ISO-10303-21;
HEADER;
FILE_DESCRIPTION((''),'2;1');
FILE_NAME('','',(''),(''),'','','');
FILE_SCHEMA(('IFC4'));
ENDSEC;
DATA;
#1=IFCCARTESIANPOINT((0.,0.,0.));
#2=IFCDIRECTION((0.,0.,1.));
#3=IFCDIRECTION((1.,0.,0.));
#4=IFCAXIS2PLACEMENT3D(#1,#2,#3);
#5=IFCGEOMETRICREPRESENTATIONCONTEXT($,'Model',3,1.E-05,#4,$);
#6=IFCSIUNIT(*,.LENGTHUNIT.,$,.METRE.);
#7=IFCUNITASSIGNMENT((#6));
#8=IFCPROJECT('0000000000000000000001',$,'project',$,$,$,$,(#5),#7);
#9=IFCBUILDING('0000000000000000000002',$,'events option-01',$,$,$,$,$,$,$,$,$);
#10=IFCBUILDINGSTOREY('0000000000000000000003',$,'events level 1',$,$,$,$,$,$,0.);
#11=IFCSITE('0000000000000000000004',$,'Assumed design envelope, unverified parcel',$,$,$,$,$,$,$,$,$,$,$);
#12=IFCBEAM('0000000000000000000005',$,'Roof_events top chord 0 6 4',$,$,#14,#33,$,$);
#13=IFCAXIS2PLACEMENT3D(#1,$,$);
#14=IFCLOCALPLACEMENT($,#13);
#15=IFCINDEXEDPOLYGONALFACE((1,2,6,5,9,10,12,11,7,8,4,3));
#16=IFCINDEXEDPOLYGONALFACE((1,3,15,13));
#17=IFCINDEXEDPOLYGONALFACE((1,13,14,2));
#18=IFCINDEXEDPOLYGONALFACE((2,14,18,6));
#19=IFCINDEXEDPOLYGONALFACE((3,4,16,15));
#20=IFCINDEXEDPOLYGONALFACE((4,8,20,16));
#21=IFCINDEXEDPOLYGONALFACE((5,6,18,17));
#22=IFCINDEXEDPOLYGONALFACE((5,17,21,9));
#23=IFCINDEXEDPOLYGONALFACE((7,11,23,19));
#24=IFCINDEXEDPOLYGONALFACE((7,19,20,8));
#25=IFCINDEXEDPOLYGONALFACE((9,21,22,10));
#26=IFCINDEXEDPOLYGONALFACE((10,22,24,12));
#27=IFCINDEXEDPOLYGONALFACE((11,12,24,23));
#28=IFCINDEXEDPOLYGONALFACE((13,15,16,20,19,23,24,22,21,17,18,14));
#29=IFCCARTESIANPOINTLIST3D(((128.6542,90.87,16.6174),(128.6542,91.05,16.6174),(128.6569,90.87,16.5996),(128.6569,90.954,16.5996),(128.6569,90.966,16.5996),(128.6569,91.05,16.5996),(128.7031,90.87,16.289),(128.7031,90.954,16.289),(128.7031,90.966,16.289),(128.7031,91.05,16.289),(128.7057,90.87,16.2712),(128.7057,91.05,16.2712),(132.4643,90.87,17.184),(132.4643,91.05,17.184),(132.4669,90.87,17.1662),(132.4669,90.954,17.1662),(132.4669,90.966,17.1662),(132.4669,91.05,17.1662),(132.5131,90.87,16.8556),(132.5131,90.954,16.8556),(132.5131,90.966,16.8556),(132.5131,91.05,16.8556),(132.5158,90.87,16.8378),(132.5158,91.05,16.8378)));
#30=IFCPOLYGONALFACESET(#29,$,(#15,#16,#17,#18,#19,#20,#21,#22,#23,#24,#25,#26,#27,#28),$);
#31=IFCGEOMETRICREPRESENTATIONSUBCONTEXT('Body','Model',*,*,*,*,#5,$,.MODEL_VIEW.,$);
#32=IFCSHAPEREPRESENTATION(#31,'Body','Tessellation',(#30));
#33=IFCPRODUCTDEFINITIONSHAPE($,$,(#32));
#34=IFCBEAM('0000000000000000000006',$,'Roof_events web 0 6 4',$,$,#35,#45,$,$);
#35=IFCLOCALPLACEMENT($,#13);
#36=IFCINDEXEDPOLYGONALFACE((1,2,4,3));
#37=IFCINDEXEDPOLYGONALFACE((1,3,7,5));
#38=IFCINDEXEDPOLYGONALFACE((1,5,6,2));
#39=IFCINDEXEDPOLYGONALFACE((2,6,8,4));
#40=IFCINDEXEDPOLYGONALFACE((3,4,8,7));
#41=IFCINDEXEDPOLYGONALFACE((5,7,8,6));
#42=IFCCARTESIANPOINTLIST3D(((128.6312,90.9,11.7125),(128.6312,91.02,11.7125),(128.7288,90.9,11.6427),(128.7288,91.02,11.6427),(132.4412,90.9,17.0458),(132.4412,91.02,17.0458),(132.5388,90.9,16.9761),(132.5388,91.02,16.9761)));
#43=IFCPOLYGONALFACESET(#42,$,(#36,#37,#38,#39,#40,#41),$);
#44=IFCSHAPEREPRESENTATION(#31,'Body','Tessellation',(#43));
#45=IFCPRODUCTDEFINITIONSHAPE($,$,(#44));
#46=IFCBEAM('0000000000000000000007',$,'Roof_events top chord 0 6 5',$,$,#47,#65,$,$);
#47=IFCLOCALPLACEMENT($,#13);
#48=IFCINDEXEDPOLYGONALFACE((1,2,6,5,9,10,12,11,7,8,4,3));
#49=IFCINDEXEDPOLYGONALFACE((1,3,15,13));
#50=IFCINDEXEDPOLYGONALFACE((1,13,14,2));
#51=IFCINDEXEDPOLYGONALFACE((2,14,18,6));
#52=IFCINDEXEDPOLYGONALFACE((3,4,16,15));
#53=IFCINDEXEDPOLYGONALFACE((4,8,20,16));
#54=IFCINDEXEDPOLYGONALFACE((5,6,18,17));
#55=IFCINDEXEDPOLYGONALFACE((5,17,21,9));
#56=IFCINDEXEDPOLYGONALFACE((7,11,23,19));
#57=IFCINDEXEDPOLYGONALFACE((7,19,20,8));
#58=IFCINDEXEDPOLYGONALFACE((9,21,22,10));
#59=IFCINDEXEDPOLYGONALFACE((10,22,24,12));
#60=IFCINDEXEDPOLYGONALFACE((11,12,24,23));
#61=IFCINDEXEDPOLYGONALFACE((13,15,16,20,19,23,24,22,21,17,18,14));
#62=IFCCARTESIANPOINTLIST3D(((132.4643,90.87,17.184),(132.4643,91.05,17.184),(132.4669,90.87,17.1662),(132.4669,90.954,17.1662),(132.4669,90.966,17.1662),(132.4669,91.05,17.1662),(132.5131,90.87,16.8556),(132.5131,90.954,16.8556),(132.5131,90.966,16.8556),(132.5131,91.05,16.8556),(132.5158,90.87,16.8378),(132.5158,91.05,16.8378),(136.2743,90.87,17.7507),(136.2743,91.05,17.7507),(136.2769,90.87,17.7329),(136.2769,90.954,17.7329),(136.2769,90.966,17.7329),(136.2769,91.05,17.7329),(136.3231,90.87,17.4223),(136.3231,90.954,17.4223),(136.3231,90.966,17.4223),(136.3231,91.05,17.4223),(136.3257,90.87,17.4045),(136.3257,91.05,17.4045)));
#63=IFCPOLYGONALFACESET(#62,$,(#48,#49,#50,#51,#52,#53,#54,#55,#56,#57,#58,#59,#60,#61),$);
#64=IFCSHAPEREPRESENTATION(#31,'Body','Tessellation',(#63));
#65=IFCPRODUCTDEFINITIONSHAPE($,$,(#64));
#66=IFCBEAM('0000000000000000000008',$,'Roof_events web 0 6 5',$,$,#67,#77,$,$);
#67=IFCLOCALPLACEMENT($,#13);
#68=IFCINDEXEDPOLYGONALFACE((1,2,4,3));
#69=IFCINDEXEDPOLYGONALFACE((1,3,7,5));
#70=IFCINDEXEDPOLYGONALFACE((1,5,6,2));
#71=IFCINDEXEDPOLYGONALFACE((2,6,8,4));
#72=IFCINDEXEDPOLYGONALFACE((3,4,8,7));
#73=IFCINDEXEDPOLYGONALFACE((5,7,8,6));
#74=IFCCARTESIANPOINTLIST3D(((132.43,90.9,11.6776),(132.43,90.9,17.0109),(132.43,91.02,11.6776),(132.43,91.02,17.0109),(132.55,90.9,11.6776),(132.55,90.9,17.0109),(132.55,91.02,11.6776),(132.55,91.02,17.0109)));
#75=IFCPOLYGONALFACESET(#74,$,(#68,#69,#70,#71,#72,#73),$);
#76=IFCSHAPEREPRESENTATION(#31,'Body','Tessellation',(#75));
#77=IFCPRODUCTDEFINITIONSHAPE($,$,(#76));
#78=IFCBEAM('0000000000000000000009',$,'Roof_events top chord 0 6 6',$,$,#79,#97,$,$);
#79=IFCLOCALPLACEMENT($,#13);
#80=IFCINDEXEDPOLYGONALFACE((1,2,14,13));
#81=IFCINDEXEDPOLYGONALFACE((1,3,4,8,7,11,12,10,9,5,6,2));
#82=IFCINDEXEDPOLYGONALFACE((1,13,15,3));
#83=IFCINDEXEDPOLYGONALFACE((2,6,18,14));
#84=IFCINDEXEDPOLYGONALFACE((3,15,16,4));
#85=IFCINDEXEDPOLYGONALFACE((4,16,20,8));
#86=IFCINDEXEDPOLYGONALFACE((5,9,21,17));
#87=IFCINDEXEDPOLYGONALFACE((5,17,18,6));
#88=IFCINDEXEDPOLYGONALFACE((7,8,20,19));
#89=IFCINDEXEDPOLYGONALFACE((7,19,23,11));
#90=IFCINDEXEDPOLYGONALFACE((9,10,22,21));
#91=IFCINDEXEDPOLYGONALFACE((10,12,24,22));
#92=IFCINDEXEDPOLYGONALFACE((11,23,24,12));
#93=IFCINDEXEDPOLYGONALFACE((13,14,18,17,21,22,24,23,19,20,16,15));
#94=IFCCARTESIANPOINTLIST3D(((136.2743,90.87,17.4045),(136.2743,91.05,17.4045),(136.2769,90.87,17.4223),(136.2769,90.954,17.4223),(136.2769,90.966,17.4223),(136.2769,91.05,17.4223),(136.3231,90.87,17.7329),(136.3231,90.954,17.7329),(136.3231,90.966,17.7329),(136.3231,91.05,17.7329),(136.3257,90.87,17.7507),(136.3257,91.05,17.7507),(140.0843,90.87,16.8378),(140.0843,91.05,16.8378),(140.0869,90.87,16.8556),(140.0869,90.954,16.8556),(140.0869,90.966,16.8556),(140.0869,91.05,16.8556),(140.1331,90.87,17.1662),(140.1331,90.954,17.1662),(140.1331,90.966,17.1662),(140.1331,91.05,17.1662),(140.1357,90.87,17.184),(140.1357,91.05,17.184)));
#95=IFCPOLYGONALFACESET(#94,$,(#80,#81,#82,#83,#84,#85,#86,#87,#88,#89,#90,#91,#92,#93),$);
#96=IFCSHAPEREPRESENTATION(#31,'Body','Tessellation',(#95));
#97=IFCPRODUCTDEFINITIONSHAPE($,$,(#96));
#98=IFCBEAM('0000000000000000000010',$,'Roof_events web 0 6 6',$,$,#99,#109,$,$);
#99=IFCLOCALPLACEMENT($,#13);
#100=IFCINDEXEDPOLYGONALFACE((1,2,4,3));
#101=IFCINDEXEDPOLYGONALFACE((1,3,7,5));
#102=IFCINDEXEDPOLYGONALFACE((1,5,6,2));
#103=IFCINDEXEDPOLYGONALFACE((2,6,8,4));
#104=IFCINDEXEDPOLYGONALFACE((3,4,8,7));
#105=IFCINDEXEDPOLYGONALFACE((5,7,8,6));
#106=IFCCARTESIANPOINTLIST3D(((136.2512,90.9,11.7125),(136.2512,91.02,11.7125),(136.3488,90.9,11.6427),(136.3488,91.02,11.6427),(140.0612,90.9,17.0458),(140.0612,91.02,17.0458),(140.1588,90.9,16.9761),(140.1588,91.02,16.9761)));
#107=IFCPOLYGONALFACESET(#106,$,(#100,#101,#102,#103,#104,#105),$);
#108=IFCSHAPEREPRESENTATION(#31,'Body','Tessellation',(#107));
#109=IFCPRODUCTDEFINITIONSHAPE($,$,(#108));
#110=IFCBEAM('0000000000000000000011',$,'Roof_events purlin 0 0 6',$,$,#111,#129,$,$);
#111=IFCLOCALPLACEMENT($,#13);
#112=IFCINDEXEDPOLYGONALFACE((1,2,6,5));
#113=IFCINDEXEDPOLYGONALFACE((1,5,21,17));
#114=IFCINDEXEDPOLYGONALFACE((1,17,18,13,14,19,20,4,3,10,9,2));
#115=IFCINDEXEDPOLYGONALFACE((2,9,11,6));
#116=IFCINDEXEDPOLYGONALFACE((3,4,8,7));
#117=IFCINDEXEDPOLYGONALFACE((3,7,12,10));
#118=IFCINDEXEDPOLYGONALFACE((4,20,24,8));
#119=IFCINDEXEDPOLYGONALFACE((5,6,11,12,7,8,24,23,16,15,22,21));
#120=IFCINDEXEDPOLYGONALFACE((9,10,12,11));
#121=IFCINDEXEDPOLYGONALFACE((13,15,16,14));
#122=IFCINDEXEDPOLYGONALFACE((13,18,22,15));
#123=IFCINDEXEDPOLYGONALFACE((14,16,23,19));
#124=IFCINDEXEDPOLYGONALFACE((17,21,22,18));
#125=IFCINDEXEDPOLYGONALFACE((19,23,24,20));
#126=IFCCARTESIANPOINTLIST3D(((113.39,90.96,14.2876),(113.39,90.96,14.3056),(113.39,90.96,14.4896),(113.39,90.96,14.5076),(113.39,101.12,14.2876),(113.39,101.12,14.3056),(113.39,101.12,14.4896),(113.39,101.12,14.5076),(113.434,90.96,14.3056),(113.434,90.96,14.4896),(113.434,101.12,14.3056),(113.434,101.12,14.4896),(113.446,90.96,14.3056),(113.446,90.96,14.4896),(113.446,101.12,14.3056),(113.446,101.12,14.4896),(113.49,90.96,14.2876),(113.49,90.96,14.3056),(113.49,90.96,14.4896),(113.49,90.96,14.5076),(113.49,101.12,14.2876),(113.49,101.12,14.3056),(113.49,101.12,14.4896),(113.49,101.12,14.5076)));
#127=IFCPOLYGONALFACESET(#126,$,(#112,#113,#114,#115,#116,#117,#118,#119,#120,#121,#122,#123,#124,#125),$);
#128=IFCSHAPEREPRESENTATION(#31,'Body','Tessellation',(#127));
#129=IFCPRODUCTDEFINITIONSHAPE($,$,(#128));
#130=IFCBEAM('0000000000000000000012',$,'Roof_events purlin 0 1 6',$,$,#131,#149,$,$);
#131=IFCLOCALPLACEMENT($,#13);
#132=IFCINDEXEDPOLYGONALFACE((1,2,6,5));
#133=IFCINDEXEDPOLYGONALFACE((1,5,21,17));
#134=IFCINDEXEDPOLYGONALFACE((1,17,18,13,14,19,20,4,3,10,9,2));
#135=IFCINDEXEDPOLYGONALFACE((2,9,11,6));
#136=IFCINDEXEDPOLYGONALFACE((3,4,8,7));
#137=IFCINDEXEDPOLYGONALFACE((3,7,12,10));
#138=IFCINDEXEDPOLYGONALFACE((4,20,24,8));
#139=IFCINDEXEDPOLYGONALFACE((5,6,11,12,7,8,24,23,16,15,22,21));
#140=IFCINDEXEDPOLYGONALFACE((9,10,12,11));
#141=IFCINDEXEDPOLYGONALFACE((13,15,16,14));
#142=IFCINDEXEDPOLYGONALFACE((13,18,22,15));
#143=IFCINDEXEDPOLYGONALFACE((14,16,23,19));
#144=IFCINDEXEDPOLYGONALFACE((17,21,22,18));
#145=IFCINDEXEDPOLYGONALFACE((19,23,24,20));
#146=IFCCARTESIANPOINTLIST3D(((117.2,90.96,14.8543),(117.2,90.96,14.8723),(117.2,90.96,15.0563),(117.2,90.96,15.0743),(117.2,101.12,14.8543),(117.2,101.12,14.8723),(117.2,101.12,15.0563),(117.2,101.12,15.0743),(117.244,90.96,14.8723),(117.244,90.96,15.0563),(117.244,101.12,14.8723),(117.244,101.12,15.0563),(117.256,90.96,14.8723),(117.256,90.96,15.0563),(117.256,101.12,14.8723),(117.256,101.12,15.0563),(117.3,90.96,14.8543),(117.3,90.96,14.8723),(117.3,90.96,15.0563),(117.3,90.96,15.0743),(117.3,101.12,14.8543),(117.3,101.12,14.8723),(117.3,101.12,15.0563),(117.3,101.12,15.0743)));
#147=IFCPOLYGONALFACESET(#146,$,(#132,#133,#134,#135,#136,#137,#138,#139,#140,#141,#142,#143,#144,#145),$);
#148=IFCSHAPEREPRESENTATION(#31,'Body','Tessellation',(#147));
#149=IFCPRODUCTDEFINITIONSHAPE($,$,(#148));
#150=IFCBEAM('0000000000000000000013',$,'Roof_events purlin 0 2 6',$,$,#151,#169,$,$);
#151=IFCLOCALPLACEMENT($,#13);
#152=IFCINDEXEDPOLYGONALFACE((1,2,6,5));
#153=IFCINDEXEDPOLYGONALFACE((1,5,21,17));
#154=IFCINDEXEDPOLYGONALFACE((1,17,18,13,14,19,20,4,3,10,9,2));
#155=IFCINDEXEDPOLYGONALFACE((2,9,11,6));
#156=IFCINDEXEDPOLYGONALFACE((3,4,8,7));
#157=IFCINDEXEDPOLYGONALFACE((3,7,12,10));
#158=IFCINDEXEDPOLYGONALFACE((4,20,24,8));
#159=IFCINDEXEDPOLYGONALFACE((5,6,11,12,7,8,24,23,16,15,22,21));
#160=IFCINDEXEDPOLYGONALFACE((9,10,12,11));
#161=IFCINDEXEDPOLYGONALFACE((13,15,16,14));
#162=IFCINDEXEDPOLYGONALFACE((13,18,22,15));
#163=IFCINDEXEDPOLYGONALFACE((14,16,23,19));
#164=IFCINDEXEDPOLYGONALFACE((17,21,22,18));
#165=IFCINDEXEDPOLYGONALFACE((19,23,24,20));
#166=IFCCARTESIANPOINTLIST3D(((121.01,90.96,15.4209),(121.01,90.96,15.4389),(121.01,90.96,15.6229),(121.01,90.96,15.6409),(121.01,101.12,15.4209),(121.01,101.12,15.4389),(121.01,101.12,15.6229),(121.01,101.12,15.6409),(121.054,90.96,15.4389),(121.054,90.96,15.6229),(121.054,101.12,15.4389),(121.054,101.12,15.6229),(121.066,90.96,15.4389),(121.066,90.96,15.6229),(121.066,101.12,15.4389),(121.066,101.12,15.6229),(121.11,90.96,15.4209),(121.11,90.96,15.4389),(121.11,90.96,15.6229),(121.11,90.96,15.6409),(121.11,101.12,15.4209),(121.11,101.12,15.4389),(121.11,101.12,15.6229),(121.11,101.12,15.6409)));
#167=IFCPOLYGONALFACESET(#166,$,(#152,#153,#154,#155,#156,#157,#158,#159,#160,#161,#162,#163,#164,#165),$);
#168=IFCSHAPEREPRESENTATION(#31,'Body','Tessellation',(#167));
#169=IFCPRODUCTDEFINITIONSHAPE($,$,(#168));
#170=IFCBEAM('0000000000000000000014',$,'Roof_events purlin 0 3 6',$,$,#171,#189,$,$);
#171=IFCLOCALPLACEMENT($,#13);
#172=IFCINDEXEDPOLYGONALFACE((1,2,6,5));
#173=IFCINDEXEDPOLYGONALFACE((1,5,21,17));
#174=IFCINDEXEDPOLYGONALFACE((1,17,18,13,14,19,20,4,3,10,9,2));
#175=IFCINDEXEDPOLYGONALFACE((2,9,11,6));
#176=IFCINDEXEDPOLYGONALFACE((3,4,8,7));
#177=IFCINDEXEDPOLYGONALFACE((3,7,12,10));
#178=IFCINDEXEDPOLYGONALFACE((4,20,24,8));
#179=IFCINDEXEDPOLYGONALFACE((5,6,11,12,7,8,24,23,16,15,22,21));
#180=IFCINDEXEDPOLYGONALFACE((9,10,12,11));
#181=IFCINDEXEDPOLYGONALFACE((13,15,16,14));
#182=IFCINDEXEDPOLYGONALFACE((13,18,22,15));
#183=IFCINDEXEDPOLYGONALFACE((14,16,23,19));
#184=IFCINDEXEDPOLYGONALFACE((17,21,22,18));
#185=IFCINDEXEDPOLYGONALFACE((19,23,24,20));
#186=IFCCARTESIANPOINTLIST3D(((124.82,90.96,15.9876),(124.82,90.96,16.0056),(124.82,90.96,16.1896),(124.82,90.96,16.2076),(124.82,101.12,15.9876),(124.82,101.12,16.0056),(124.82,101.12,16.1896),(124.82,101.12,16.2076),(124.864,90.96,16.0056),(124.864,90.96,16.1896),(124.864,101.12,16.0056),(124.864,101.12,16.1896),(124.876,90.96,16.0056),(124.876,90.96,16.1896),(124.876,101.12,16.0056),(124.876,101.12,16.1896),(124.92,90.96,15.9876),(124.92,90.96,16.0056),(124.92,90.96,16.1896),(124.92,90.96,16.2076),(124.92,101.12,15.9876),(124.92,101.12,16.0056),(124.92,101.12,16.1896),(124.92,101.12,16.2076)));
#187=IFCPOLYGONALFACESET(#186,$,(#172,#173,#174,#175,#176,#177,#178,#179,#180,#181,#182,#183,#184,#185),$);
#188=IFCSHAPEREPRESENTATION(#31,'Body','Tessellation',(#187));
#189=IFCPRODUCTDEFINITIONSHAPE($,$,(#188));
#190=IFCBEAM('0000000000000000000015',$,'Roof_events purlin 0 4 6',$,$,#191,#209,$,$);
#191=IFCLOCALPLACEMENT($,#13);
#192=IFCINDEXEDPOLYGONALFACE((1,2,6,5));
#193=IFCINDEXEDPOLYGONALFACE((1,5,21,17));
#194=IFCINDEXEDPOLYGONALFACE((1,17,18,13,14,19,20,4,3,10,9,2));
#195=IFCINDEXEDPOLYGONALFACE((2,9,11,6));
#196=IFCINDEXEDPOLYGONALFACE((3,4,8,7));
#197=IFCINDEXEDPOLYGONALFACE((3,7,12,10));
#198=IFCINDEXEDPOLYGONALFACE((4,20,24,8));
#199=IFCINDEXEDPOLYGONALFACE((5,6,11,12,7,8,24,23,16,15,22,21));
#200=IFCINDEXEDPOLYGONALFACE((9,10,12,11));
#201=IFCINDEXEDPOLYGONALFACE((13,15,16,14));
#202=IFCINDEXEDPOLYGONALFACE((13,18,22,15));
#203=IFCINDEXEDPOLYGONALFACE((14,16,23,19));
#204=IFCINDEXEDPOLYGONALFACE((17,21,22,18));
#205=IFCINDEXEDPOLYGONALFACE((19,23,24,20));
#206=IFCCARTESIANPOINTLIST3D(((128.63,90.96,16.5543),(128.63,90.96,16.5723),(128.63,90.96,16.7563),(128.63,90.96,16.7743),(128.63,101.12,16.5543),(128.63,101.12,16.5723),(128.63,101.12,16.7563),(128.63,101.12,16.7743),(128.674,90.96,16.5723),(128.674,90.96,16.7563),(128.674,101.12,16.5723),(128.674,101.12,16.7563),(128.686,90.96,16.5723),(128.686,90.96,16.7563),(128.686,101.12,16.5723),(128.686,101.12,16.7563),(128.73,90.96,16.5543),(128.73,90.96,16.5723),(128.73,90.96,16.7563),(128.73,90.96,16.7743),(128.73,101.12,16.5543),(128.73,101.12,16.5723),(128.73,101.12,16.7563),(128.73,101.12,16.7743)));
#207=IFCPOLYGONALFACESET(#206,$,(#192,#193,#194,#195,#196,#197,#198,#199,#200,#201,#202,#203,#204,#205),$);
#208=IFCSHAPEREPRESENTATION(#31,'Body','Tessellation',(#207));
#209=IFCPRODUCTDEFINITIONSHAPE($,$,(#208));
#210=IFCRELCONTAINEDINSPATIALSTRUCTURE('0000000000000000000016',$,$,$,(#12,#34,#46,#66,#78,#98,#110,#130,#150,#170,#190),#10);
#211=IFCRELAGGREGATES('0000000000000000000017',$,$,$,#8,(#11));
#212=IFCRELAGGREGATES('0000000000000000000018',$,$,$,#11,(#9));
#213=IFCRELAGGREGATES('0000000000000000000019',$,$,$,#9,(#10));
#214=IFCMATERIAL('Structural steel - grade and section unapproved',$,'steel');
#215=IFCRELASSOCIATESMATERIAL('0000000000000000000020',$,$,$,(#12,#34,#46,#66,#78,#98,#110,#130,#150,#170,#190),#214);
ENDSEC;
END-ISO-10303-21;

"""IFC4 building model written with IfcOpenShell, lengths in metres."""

from ifc_helpers import new_model, si_unit, frame, origin_with_axes, place, context, subcontext, project, spatial, rectangle, i_section, extrude, material, element, save


model = new_model("IFC4")

# Units and contexts
model_context = context("Model", 3, precision=1e-05, world=origin_with_axes())
body_context = subcontext(model_context, "Body", "Model", "MODEL_VIEW")
ifc_project = project(units=[si_unit("LENGTHUNIT", "METRE")], contexts=[model_context])

# Site, building, storey
site = spatial("IfcSite", under=ifc_project, Name="Assumed design envelope, unverified parcel")
building = spatial("IfcBuilding", under=site, Name="events option-01")
storey = spatial("IfcBuildingStorey", under=building, Name="events level 1", Elevation=0.0)

# Shared definitions
ifc_material_1 = material(Name="Structural steel - grade and section unapproved", Category="steel")

# Beams
beam_1_placement = place(None, frame((128.68, 90.96, 16.4443), z_axis=(0.98912, 0.0, 0.147112), x_axis=(0.0, 1.0, 0.0)))
element("IfcBeam", 1, at=beam_1_placement, inside=storey, material=ifc_material_1, Name="Roof_events top chord 0 6 4", context=body_context, shape_type="SweptSolid", body=[
    extrude(i_section(OverallWidth=0.18, OverallDepth=0.35, WebThickness=0.012, FlangeThickness=0.018, FilletRadius=0.0), origin_with_axes(), (0.0, 0.0, 1.0), 3.8519),
])
beam_2_placement = place(None, frame((128.68, 90.96, 11.6776), z_axis=(0.581288, 0.0, 0.813698), x_axis=(0.0, 1.0, 0.0)))
element("IfcBeam", 2, at=beam_2_placement, inside=storey, material=ifc_material_1, Name="Roof_events web 0 6 4", context=body_context, shape_type="SweptSolid", body=[
    extrude(rectangle(XDim=0.12, YDim=0.12), origin_with_axes(), (0.0, 0.0, 1.0), 6.5544),
])
beam_3_placement = place(None, frame((132.49, 90.96, 17.0109), z_axis=(0.98912, 0.0, 0.147113), x_axis=(0.0, 1.0, 0.0)))
element("IfcBeam", 3, at=beam_3_placement, inside=storey, material=ifc_material_1, Name="Roof_events top chord 0 6 5", context=body_context, shape_type="SweptSolid", body=[
    extrude(i_section(OverallWidth=0.18, OverallDepth=0.35, WebThickness=0.012, FlangeThickness=0.018, FilletRadius=0.0), origin_with_axes(), (0.0, 0.0, 1.0), 3.8519),
])
beam_4_placement = place(None, frame((132.49, 90.96, 11.6776), z_axis=(0.0, 0.0, 1.0), x_axis=(-1.0, 0.0, 0.0)))
element("IfcBeam", 4, at=beam_4_placement, inside=storey, material=ifc_material_1, Name="Roof_events web 0 6 5", context=body_context, shape_type="SweptSolid", body=[
    extrude(rectangle(XDim=0.12, YDim=0.12), origin_with_axes(), (0.0, 0.0, 1.0), 5.3333),
])
beam_5_placement = place(None, frame((136.3, 90.96, 17.5776), z_axis=(0.98912, 0.0, -0.147113), x_axis=(0.0, 1.0, 0.0)))
element("IfcBeam", 5, at=beam_5_placement, inside=storey, material=ifc_material_1, Name="Roof_events top chord 0 6 6", context=body_context, shape_type="SweptSolid", body=[
    extrude(i_section(OverallWidth=0.18, OverallDepth=0.35, WebThickness=0.012, FlangeThickness=0.018, FilletRadius=0.0), origin_with_axes(), (0.0, 0.0, 1.0), 3.8519),
])
beam_6_placement = place(None, frame((136.3, 90.96, 11.6776), z_axis=(0.581286, 0.0, 0.813699), x_axis=(0.0, 1.0, 0.0)))
element("IfcBeam", 6, at=beam_6_placement, inside=storey, material=ifc_material_1, Name="Roof_events web 0 6 6", context=body_context, shape_type="SweptSolid", body=[
    extrude(rectangle(XDim=0.12, YDim=0.12), origin_with_axes(), (0.0, 0.0, 1.0), 6.5544),
])
for number, where, z_axis, x_axis, name in (
    (7, (113.44, 90.96, 14.3976), (0.0, 1.0, 0.0), (-1.0, 0.0, 0.0), "Roof_events purlin 0 0 6"),
    (8, (117.25, 90.96, 14.9643), (0.0, 1.0, 0.0), (-1.0, 0.0, 0.0), "Roof_events purlin 0 1 6"),
    (9, (121.06, 90.96, 15.5309), (0.0, 1.0, 0.0), (-1.0, 0.0, 0.0), "Roof_events purlin 0 2 6"),
    (10, (124.87, 90.96, 16.0976), (0.0, 1.0, 0.0), (-1.0, 0.0, 0.0), "Roof_events purlin 0 3 6"),
    (11, (128.68, 90.96, 16.6643), (0.0, 1.0, 0.0), (-1.0, 0.0, 0.0), "Roof_events purlin 0 4 6"),
):
    element("IfcBeam", number, at=place(None, frame(where, z_axis=z_axis, x_axis=x_axis)), inside=storey, material=ifc_material_1, Name=name, context=body_context, shape_type="SweptSolid", body=[
        extrude(i_section(OverallWidth=0.1, OverallDepth=0.22, WebThickness=0.012, FlangeThickness=0.018, FilletRadius=0.0), origin_with_axes(), (0.0, 0.0, 1.0), 10.16),
    ])

save(model, "model.ifc")
